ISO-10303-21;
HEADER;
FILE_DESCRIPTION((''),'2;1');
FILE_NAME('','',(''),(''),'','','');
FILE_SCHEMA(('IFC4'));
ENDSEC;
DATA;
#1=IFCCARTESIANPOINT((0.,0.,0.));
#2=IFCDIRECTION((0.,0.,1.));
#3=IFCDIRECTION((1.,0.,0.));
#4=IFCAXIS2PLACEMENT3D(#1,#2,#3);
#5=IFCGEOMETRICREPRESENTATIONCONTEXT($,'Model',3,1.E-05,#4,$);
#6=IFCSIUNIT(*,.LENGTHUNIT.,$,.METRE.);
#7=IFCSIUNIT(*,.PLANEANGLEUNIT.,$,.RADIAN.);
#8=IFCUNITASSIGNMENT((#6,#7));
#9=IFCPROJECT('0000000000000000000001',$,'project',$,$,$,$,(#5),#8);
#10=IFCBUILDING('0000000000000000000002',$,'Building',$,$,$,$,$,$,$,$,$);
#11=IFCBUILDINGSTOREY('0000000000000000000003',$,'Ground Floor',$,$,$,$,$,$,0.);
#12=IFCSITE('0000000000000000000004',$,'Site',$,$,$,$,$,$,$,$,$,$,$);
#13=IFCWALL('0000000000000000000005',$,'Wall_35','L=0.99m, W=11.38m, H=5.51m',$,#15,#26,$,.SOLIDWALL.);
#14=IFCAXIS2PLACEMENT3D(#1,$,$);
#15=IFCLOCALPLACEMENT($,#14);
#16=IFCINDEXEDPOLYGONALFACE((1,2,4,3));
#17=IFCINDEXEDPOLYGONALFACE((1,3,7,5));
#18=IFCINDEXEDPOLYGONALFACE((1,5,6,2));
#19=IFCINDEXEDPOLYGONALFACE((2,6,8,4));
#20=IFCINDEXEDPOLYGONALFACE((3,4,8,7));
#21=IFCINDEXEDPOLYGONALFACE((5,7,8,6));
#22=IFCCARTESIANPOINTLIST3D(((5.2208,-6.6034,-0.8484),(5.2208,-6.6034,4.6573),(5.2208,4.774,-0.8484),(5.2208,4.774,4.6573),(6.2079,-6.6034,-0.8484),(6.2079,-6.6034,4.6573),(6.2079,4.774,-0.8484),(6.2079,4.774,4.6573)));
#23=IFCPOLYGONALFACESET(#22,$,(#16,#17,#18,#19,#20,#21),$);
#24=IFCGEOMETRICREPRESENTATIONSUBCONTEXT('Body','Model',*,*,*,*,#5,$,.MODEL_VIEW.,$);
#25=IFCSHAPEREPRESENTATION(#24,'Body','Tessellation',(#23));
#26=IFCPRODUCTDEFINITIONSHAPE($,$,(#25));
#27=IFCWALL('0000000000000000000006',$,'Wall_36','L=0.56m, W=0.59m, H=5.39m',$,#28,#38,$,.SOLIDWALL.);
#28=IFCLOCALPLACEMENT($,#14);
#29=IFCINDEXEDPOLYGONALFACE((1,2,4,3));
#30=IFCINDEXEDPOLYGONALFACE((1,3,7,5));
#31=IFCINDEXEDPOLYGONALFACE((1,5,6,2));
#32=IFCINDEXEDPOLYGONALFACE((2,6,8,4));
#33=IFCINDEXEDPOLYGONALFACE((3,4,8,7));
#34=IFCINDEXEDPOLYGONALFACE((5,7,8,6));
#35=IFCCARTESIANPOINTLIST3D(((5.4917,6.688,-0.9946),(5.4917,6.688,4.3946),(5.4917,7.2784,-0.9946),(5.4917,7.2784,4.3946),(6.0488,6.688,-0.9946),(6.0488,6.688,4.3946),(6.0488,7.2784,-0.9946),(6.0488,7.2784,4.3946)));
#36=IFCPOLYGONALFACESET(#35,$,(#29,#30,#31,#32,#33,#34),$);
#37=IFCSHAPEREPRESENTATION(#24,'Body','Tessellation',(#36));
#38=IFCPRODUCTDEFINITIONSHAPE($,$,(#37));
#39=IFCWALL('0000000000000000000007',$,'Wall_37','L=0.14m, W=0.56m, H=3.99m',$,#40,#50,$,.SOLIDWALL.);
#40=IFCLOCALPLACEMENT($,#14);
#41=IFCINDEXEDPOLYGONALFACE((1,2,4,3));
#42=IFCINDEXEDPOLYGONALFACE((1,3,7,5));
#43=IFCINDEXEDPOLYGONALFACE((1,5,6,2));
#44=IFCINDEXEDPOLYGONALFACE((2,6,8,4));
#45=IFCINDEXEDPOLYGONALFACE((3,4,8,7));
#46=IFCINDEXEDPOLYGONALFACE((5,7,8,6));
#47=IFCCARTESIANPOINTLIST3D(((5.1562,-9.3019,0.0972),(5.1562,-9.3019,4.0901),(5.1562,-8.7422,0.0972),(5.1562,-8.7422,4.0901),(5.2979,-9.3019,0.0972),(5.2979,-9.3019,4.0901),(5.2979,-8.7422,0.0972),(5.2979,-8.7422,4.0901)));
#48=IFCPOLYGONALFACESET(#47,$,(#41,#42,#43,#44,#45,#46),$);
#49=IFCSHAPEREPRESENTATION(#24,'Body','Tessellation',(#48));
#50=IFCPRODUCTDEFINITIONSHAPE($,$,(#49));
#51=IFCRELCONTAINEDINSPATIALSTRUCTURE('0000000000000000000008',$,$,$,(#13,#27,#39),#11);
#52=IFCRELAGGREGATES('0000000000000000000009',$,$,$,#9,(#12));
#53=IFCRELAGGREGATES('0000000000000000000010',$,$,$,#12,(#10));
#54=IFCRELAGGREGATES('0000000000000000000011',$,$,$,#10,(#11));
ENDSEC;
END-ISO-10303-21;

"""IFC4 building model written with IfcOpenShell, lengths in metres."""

from ifc_helpers import new_model, si_unit, frame, origin_with_axes, origin_2d, context, subcontext, project, spatial, rectangle, extrude, element, save


model = new_model("IFC4")

# Units and contexts
model_context = context("Model", 3, precision=1e-05, world=origin_with_axes())
body_context = subcontext(model_context, "Body", "Model", "MODEL_VIEW")
ifc_project = project(units=[si_unit("LENGTHUNIT", "METRE"), si_unit("PLANEANGLEUNIT", "RADIAN")], contexts=[model_context])

# Site, building, storey
site = spatial("IfcSite", under=ifc_project, Name="Site")
building = spatial("IfcBuilding", under=site, Name="Building")
storey = spatial("IfcBuildingStorey", under=building, Name="Ground Floor", Elevation=0.0)

# Walls
element("IfcWall", 1, inside=storey, Name="Wall_35", Description="L=0.99m, W=11.38m, H=5.51m", PredefinedType="SOLIDWALL", context=body_context, shape_type="SweptSolid", body=[
    extrude(rectangle(XDim=0.9872, YDim=11.3773, at=origin_2d()), frame((5.7144, -0.9147, -0.8484), z_axis=(0.0, 0.0, 1.0), x_axis=(1.0, 0.0, 0.0)), (0.0, 0.0, 1.0), 5.5057),
])
element("IfcWall", 2, inside=storey, Name="Wall_36", Description="L=0.56m, W=0.59m, H=5.39m", PredefinedType="SOLIDWALL", context=body_context, shape_type="SweptSolid", body=[
    extrude(rectangle(XDim=0.557, YDim=0.5904, at=origin_2d()), frame((5.7703, 6.9832, -0.9946), z_axis=(0.0, 0.0, 1.0), x_axis=(1.0, 0.0, 0.0)), (0.0, 0.0, 1.0), 5.3891),
])
element("IfcWall", 3, inside=storey, Name="Wall_37", Description="L=0.14m, W=0.56m, H=3.99m", PredefinedType="SOLIDWALL", context=body_context, shape_type="SweptSolid", body=[
    extrude(rectangle(XDim=0.1417, YDim=0.5597, at=origin_2d()), frame((5.227, -9.0221, 0.0972), z_axis=(0.0, 0.0, 1.0), x_axis=(1.0, 0.0, 0.0)), (0.0, 0.0, 1.0), 3.9929),
])

save(model, "model.ifc")
